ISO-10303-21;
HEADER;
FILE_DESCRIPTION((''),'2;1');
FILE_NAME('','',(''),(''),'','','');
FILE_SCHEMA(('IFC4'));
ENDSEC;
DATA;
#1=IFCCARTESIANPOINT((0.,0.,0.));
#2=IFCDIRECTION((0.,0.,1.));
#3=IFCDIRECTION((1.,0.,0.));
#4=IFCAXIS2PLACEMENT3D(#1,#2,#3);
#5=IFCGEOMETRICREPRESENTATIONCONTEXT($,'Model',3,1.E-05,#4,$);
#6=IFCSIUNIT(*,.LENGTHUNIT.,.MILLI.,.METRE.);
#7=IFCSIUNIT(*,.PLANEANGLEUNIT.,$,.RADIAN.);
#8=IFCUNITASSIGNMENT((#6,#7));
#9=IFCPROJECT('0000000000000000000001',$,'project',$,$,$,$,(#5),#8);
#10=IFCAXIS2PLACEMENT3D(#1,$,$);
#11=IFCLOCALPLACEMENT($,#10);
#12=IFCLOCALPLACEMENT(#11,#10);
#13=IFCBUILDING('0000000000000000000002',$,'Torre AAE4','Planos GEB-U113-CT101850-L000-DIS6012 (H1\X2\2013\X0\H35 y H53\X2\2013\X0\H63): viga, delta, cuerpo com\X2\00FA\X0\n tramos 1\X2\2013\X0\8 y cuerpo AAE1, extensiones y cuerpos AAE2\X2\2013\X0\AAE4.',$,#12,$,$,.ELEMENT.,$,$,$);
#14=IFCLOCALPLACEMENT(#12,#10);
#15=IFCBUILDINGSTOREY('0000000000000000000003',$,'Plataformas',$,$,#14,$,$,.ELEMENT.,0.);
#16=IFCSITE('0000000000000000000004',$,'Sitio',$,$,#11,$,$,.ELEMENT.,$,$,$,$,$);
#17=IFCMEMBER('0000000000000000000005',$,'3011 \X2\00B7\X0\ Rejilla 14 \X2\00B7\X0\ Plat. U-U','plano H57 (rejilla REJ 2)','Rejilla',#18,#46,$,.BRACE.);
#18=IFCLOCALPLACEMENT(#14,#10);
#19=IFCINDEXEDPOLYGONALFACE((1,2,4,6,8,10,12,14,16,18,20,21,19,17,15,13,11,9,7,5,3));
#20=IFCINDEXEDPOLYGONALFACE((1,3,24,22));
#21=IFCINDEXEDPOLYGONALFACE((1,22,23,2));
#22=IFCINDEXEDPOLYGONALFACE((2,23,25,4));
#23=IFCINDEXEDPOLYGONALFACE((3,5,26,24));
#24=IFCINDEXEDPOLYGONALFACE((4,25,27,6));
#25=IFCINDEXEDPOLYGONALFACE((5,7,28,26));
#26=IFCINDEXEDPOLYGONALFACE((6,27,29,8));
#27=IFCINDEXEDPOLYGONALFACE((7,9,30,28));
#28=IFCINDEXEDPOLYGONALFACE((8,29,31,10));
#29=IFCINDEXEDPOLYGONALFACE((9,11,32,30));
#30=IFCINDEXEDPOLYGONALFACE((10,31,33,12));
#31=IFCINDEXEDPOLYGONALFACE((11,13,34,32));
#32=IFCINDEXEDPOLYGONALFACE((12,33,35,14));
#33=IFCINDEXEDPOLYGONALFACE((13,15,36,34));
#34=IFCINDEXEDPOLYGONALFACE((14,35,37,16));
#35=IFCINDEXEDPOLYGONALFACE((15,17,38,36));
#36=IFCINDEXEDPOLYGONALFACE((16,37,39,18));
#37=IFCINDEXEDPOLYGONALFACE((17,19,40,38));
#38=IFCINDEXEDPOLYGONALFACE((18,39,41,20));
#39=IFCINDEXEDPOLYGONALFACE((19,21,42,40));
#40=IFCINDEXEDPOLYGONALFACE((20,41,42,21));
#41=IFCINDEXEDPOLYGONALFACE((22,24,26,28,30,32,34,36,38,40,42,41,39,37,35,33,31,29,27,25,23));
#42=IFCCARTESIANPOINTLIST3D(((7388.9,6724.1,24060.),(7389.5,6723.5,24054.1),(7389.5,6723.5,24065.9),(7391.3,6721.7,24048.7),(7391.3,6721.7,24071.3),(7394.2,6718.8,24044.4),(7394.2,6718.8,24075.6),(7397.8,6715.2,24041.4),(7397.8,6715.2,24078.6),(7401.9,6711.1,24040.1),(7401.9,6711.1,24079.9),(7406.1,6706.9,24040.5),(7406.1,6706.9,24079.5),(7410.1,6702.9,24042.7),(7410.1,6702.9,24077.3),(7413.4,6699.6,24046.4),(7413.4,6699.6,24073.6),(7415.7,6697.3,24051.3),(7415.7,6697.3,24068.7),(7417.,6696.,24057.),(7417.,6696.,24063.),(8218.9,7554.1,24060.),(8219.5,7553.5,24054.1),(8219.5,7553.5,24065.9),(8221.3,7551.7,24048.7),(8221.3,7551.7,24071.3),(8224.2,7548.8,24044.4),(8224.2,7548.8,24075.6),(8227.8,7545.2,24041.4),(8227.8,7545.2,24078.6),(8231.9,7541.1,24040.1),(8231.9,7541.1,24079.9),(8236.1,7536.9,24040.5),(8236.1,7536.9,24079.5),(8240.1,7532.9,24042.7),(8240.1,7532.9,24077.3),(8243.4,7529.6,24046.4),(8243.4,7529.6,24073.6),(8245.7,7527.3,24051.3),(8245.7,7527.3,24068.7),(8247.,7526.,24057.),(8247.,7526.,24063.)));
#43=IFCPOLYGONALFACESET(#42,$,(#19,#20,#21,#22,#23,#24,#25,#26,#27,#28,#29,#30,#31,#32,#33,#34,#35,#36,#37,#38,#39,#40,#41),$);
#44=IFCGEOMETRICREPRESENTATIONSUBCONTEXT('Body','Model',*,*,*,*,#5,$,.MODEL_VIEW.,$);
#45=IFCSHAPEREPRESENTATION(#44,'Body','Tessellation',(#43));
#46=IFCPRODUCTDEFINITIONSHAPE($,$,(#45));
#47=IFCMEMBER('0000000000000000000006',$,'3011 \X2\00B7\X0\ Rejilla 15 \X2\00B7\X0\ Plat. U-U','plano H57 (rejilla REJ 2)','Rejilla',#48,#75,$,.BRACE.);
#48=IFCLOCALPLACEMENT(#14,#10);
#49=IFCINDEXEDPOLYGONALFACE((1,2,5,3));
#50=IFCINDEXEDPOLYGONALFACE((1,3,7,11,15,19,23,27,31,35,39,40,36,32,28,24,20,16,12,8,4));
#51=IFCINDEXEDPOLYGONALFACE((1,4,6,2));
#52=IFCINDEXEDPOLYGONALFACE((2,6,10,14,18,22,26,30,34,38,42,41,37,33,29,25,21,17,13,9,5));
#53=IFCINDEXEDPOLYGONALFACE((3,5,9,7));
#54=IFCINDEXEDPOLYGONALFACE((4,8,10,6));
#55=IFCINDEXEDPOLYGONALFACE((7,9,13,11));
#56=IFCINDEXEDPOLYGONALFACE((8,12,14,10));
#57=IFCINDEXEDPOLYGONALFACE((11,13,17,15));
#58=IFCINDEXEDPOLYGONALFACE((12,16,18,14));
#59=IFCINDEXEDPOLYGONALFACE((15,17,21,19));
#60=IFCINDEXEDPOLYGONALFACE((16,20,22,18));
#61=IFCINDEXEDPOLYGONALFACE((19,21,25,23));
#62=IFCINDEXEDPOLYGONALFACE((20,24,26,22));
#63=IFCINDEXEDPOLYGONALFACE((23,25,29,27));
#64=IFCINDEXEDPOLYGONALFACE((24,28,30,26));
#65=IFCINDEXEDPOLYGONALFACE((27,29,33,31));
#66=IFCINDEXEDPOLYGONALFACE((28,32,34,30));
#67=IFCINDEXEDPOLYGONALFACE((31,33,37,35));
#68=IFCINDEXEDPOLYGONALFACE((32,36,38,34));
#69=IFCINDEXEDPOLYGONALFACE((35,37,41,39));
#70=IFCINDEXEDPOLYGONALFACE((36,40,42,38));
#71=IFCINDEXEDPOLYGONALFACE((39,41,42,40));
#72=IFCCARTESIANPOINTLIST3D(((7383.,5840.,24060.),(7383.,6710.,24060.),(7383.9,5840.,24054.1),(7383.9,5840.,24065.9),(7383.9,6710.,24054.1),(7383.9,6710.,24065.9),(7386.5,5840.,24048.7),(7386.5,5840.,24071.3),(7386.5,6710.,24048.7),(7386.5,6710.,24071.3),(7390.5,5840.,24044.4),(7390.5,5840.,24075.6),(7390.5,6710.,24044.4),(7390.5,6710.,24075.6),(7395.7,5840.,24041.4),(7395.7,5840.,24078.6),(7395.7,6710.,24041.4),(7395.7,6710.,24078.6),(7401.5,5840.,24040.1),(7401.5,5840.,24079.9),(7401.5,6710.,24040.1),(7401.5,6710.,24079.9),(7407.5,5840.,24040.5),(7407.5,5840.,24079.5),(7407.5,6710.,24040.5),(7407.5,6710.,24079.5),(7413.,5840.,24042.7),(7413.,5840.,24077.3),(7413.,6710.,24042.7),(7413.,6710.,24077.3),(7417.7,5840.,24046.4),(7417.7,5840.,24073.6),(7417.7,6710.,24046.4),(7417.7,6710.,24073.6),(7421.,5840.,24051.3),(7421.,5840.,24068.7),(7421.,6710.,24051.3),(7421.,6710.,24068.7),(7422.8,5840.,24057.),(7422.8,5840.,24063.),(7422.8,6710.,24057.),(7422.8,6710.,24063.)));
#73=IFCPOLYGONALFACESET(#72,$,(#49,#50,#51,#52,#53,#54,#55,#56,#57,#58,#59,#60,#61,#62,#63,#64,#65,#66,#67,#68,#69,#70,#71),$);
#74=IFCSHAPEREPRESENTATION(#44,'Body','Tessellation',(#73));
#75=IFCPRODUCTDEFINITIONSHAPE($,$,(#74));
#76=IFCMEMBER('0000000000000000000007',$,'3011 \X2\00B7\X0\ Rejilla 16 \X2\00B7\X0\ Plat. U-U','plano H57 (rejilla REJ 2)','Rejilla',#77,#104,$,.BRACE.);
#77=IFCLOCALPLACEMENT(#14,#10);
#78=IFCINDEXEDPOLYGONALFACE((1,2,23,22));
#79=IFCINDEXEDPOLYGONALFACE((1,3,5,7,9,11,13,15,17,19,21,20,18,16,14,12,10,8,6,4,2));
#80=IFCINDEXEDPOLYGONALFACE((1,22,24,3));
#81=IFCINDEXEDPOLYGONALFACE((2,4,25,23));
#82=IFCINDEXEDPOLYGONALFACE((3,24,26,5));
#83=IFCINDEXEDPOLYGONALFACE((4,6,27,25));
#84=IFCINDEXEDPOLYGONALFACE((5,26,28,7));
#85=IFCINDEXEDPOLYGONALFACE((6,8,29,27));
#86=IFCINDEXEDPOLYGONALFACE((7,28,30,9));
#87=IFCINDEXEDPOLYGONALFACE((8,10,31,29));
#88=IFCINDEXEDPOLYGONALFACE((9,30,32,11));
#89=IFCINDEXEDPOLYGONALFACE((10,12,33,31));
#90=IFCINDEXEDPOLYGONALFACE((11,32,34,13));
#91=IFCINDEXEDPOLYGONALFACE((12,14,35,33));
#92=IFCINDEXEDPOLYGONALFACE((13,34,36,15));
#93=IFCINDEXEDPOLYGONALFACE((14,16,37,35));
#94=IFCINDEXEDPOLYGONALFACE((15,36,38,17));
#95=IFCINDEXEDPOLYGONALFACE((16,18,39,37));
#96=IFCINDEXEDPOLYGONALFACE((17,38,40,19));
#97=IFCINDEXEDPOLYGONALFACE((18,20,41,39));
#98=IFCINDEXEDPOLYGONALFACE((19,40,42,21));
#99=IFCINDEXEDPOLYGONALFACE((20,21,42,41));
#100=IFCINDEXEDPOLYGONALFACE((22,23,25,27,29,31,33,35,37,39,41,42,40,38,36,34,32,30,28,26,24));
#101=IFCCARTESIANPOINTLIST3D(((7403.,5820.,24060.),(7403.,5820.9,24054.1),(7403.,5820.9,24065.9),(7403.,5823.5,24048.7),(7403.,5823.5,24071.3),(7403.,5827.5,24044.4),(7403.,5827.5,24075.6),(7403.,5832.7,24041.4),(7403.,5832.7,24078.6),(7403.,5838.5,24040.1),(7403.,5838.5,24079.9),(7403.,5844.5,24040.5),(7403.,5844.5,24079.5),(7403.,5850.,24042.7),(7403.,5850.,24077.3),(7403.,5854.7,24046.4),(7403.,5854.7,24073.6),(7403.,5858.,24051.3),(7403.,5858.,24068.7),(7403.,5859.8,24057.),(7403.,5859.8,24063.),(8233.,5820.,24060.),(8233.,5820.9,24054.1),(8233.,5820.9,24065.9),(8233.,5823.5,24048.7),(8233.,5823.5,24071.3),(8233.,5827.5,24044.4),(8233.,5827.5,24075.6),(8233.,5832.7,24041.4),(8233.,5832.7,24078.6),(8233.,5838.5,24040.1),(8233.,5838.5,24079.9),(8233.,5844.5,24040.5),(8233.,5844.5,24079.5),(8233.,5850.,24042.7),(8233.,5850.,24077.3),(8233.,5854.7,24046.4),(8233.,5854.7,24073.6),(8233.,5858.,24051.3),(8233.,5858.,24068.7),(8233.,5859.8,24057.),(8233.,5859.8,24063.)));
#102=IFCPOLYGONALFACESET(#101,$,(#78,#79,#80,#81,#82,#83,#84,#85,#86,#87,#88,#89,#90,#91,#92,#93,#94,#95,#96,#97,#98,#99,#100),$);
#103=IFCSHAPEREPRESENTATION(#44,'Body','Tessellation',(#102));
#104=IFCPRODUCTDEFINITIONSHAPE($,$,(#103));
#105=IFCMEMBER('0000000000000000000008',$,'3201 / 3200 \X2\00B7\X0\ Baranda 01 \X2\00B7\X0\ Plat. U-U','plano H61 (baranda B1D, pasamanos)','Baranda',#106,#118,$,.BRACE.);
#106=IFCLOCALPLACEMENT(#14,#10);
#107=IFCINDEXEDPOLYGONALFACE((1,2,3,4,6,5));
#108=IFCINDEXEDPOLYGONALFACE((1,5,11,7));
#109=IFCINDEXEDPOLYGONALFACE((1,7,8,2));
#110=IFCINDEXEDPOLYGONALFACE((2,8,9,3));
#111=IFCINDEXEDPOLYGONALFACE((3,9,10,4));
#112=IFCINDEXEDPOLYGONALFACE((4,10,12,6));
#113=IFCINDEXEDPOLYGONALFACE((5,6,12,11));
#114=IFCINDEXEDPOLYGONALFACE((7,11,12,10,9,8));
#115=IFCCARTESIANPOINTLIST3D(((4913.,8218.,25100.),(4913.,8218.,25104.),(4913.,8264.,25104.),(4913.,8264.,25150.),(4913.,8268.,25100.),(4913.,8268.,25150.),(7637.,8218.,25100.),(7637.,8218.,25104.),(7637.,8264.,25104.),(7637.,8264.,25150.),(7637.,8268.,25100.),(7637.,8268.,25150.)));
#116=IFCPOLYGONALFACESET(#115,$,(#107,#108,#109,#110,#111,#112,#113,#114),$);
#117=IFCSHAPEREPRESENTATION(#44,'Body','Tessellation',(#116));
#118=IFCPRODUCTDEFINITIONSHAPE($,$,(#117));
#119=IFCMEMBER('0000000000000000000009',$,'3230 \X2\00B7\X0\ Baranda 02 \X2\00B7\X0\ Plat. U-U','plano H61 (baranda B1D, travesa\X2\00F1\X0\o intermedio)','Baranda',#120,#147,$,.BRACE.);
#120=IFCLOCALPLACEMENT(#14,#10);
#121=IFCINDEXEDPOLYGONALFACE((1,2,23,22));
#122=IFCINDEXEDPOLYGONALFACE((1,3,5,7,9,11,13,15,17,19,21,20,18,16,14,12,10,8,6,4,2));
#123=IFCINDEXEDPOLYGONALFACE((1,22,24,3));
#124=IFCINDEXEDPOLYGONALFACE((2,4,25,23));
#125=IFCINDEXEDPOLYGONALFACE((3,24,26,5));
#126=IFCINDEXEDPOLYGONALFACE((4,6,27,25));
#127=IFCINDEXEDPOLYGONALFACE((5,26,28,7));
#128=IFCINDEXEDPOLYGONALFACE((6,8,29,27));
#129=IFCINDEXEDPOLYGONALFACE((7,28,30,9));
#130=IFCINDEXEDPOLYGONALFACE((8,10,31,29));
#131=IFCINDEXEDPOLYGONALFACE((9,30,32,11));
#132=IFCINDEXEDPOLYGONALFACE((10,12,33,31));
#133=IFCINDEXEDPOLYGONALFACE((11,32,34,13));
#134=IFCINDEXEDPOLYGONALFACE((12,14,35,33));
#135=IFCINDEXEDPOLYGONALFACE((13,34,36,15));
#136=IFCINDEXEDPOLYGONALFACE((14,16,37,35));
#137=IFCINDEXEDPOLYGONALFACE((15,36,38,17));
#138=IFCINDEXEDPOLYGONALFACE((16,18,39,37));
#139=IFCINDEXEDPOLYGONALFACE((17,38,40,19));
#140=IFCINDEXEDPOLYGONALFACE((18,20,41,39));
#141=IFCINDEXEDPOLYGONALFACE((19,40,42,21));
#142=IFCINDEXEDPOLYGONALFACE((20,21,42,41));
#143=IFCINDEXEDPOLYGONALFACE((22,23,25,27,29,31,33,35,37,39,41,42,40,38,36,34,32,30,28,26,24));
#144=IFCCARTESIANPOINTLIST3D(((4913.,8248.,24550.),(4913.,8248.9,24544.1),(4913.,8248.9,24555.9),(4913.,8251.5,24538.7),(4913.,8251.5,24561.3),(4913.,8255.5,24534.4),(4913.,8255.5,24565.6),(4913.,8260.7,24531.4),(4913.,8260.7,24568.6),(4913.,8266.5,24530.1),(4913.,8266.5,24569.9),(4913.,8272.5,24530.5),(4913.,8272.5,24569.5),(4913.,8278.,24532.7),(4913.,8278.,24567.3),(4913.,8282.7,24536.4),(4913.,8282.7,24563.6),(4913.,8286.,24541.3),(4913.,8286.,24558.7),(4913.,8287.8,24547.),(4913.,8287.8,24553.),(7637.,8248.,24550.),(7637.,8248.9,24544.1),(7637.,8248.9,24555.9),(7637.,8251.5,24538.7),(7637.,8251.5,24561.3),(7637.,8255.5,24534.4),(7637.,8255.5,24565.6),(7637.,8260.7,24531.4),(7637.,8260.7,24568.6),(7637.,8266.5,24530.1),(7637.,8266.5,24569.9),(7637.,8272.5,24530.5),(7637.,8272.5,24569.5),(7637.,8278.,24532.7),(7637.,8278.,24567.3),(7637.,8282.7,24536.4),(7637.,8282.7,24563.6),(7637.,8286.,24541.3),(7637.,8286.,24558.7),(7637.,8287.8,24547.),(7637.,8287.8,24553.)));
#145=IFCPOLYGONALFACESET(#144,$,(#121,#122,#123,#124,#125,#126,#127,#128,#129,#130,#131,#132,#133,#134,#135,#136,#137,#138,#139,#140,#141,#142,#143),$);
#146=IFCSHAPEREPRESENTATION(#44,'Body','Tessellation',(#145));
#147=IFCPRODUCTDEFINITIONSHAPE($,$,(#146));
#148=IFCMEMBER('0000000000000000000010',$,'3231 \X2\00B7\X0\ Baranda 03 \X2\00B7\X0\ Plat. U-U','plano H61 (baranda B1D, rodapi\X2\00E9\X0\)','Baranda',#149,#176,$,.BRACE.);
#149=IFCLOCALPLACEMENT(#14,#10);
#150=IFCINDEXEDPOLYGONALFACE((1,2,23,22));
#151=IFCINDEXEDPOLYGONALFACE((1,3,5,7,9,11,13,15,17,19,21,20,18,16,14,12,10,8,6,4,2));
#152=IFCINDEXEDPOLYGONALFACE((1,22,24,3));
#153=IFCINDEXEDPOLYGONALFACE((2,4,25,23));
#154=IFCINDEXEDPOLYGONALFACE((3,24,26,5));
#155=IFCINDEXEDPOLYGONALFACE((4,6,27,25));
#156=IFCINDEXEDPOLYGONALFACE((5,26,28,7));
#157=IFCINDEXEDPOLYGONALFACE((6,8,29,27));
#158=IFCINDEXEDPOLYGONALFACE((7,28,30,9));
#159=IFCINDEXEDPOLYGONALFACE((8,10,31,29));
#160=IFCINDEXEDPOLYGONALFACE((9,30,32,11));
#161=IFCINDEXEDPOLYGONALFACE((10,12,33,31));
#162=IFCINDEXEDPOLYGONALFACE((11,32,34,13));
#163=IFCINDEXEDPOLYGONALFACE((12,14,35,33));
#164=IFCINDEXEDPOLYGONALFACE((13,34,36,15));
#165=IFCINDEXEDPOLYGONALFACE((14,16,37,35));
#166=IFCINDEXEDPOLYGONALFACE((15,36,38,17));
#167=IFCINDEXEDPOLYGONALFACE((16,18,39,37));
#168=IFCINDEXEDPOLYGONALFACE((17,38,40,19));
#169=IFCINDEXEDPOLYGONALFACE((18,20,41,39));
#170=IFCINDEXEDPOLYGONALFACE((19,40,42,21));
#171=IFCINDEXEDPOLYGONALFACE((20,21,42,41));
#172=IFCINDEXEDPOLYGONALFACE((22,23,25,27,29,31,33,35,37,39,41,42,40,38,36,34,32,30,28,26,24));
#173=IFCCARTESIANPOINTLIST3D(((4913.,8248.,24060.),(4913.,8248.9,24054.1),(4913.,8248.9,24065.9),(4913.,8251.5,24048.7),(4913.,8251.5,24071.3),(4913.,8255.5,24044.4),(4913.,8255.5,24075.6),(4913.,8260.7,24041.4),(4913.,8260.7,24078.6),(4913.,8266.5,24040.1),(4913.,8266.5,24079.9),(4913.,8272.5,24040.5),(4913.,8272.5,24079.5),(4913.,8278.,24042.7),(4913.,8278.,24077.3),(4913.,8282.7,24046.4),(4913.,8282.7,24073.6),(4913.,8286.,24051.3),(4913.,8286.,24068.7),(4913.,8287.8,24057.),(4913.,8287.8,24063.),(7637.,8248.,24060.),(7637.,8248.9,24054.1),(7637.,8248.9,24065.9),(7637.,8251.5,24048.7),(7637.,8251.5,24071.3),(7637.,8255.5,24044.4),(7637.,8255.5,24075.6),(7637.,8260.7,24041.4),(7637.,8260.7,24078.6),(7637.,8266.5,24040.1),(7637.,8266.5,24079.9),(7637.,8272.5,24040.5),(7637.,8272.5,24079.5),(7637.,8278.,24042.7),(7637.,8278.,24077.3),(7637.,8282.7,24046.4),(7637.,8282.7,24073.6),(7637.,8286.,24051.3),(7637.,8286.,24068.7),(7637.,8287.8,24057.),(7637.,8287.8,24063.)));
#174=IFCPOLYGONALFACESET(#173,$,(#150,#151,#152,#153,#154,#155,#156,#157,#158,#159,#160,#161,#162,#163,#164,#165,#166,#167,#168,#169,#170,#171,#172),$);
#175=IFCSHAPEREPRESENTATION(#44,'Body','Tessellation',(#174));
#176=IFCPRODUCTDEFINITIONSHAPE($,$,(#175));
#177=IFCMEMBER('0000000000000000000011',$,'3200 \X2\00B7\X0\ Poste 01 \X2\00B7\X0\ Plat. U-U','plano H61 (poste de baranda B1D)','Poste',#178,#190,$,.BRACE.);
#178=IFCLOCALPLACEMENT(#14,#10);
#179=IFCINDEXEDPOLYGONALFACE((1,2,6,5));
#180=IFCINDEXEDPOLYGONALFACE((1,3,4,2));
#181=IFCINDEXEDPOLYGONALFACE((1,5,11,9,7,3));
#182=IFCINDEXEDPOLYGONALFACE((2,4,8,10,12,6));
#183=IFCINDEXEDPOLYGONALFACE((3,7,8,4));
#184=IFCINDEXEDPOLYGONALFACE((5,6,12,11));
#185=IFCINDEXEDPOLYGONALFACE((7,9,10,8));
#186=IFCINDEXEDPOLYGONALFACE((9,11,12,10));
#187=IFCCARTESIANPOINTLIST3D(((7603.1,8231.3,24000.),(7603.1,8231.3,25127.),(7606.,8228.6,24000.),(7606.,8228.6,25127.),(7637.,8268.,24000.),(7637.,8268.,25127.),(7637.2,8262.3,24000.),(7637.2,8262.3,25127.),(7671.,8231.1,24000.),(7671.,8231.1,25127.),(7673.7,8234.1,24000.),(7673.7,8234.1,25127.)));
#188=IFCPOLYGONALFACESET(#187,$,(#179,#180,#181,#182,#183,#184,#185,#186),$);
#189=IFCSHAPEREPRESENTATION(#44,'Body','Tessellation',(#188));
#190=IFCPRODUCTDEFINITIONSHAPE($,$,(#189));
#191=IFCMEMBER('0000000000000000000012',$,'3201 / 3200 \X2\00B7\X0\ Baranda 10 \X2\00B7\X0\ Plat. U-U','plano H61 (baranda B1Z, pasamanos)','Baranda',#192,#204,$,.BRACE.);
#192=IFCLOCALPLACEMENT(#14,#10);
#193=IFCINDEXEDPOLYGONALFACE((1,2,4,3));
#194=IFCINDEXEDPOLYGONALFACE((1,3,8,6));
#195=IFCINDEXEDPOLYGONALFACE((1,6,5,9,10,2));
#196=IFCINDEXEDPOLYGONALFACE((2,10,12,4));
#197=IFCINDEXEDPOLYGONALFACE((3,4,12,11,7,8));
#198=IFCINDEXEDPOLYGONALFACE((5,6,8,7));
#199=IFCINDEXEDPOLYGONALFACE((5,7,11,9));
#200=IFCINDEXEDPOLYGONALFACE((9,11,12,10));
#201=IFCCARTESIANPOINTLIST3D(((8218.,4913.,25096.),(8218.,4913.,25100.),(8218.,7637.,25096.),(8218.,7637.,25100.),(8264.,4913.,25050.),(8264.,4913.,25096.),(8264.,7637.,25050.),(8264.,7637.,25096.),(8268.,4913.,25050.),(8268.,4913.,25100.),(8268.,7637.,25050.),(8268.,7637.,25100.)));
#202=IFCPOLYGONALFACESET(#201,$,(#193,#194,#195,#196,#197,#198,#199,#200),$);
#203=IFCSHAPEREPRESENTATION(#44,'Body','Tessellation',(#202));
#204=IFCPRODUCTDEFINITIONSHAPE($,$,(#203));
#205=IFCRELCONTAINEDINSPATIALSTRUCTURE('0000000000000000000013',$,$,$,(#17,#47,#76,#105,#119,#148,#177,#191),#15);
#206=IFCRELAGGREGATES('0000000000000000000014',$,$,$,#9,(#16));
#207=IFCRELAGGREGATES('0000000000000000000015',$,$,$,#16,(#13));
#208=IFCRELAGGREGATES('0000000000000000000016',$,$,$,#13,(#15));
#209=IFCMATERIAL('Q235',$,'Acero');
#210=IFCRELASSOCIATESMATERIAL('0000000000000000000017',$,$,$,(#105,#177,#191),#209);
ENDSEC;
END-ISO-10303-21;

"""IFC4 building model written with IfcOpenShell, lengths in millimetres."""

from ifc_helpers import new_model, si_unit, frame, frame_2d, origin, origin_with_axes, place, context, subcontext, project, spatial, circle, l_section, extrude, material, element, save


model = new_model("IFC4")

# Units and contexts
model_context = context("Model", 3, precision=1e-05, world=origin_with_axes())
body_context = subcontext(model_context, "Body", "Model", "MODEL_VIEW")
ifc_project = project(units=[si_unit("LENGTHUNIT", "METRE", prefix="MILLI"), si_unit("PLANEANGLEUNIT", "RADIAN")], contexts=[model_context])

# Site, building, storey
site_placement = place(None, origin())
site = spatial("IfcSite", under=ifc_project, at=site_placement, Name="Sitio", CompositionType="ELEMENT")
building_placement = place(site_placement, origin())
building = spatial("IfcBuilding", under=site, at=building_placement, Name="Torre AAE4", Description="Planos GEB-U113-CT101850-L000-DIS6012 (H1–H35 y H53–H63): viga, delta, cuerpo común tramos 1–8 y cuerpo AAE1, extensiones y cuerpos AAE2–AAE4.", CompositionType="ELEMENT")
storey_placement = place(building_placement, origin())
storey = spatial("IfcBuildingStorey", under=building, at=storey_placement, Name="Plataformas", CompositionType="ELEMENT", Elevation=0.0)

# Members
member_1_placement = place(storey_placement, frame((8233.0, 7540.0, 24060.0), z_axis=(-0.707107, -0.707107, 0.0), x_axis=(-0.707107, 0.707107, 0.0)))
element("IfcMember", 1, at=member_1_placement, inside=storey, Name="3011 · Rejilla 14 · Plat. U-U", Description="plano H57 (rejilla REJ 2)", ObjectType="Rejilla", PredefinedType="BRACE", context=body_context, shape_type="SweptSolid", body=[
    extrude(circle(Radius=20.0), None, (0.0, 0.0, 1.0), 1173.8),
])
member_2_placement = place(storey_placement, frame((7403.0, 6710.0, 24060.0), z_axis=(0.0, -1.0, 0.0), x_axis=(-1.0, 0.0, 0.0)))
element("IfcMember", 2, at=member_2_placement, inside=storey, Name="3011 · Rejilla 15 · Plat. U-U", Description="plano H57 (rejilla REJ 2)", ObjectType="Rejilla", PredefinedType="BRACE", context=body_context, shape_type="SweptSolid", body=[
    extrude(circle(Radius=20.0), None, (0.0, 0.0, 1.0), 870.0),
])
member_3_placement = place(storey_placement, frame((7403.0, 5840.0, 24060.0), z_axis=(1.0, 0.0, 0.0), x_axis=(0.0, -1.0, 0.0)))
element("IfcMember", 3, at=member_3_placement, inside=storey, Name="3011 · Rejilla 16 · Plat. U-U", Description="plano H57 (rejilla REJ 2)", ObjectType="Rejilla", PredefinedType="BRACE", context=body_context, shape_type="SweptSolid", body=[
    extrude(circle(Radius=20.0), None, (0.0, 0.0, 1.0), 830.0),
])
ifc_material = material(Name="Q235", Category="Acero")
member_4_placement = place(storey_placement, frame((7637.0, 8268.0, 25100.0), z_axis=(-1.0, 0.0, 0.0), x_axis=(0.0, -1.0, 0.0)))
element("IfcMember", 4, at=member_4_placement, inside=storey, material=ifc_material, Name="3201 / 3200 · Baranda 01 · Plat. U-U", Description="plano H61 (baranda B1D, pasamanos)", ObjectType="Baranda", PredefinedType="BRACE", context=body_context, shape_type="SweptSolid", body=[
    extrude(l_section(Depth=50.0, Width=50.0, Thickness=4.0, at=frame_2d((25.0, 25.0))), None, (0.0, 0.0, 1.0), 2724.0),
])
for number, where, z_axis, x_axis, name, description in (
    (5, (7637.0, 8268.0, 24550.0), (-1.0, 0.0, 0.0), (0.0, -1.0, 0.0), "3230 · Baranda 02 · Plat. U-U", "plano H61 (baranda B1D, travesaño intermedio)"),
    (6, (7637.0, 8268.0, 24060.0), (-1.0, 0.0, 0.0), (0.0, -1.0, 0.0), "3231 · Baranda 03 · Plat. U-U", "plano H61 (baranda B1D, rodapié)"),
):
    element("IfcMember", number, at=place(storey_placement, frame(where, z_axis=z_axis, x_axis=x_axis)), inside=storey, Name=name, Description=description, ObjectType="Baranda", PredefinedType="BRACE", context=body_context, shape_type="SweptSolid", body=[
        extrude(circle(Radius=20.0), None, (0.0, 0.0, 1.0), 2724.0),
    ])
member_5_placement = place(storey_placement, frame((7637.0, 8268.0, 24000.0), z_axis=(0.0, 0.0, 1.0), x_axis=(-0.67852, -0.734582, 0.0)))
element("IfcMember", 7, at=member_5_placement, inside=storey, material=ifc_material, Name="3200 · Poste 01 · Plat. U-U", Description="plano H61 (poste de baranda B1D)", ObjectType="Poste", PredefinedType="BRACE", context=body_context, shape_type="SweptSolid", body=[
    extrude(l_section(Depth=50.0, Width=50.0, Thickness=4.0, at=frame_2d((25.0, 25.0))), None, (0.0, 0.0, 1.0), 1127.0),
])
member_6_placement = place(storey_placement, frame((8268.0, 7637.0, 25100.0), z_axis=(0.0, -1.0, 0.0), x_axis=(-1.0, 0.0, 0.0)))
element("IfcMember", 8, at=member_6_placement, inside=storey, material=ifc_material, Name="3201 / 3200 · Baranda 10 · Plat. U-U", Description="plano H61 (baranda B1Z, pasamanos)", ObjectType="Baranda", PredefinedType="BRACE", context=body_context, shape_type="SweptSolid", body=[
    extrude(l_section(Depth=50.0, Width=50.0, Thickness=4.0, at=frame_2d((25.0, 25.0))), None, (0.0, 0.0, 1.0), 2724.0),
])

save(model, "model.ifc")
